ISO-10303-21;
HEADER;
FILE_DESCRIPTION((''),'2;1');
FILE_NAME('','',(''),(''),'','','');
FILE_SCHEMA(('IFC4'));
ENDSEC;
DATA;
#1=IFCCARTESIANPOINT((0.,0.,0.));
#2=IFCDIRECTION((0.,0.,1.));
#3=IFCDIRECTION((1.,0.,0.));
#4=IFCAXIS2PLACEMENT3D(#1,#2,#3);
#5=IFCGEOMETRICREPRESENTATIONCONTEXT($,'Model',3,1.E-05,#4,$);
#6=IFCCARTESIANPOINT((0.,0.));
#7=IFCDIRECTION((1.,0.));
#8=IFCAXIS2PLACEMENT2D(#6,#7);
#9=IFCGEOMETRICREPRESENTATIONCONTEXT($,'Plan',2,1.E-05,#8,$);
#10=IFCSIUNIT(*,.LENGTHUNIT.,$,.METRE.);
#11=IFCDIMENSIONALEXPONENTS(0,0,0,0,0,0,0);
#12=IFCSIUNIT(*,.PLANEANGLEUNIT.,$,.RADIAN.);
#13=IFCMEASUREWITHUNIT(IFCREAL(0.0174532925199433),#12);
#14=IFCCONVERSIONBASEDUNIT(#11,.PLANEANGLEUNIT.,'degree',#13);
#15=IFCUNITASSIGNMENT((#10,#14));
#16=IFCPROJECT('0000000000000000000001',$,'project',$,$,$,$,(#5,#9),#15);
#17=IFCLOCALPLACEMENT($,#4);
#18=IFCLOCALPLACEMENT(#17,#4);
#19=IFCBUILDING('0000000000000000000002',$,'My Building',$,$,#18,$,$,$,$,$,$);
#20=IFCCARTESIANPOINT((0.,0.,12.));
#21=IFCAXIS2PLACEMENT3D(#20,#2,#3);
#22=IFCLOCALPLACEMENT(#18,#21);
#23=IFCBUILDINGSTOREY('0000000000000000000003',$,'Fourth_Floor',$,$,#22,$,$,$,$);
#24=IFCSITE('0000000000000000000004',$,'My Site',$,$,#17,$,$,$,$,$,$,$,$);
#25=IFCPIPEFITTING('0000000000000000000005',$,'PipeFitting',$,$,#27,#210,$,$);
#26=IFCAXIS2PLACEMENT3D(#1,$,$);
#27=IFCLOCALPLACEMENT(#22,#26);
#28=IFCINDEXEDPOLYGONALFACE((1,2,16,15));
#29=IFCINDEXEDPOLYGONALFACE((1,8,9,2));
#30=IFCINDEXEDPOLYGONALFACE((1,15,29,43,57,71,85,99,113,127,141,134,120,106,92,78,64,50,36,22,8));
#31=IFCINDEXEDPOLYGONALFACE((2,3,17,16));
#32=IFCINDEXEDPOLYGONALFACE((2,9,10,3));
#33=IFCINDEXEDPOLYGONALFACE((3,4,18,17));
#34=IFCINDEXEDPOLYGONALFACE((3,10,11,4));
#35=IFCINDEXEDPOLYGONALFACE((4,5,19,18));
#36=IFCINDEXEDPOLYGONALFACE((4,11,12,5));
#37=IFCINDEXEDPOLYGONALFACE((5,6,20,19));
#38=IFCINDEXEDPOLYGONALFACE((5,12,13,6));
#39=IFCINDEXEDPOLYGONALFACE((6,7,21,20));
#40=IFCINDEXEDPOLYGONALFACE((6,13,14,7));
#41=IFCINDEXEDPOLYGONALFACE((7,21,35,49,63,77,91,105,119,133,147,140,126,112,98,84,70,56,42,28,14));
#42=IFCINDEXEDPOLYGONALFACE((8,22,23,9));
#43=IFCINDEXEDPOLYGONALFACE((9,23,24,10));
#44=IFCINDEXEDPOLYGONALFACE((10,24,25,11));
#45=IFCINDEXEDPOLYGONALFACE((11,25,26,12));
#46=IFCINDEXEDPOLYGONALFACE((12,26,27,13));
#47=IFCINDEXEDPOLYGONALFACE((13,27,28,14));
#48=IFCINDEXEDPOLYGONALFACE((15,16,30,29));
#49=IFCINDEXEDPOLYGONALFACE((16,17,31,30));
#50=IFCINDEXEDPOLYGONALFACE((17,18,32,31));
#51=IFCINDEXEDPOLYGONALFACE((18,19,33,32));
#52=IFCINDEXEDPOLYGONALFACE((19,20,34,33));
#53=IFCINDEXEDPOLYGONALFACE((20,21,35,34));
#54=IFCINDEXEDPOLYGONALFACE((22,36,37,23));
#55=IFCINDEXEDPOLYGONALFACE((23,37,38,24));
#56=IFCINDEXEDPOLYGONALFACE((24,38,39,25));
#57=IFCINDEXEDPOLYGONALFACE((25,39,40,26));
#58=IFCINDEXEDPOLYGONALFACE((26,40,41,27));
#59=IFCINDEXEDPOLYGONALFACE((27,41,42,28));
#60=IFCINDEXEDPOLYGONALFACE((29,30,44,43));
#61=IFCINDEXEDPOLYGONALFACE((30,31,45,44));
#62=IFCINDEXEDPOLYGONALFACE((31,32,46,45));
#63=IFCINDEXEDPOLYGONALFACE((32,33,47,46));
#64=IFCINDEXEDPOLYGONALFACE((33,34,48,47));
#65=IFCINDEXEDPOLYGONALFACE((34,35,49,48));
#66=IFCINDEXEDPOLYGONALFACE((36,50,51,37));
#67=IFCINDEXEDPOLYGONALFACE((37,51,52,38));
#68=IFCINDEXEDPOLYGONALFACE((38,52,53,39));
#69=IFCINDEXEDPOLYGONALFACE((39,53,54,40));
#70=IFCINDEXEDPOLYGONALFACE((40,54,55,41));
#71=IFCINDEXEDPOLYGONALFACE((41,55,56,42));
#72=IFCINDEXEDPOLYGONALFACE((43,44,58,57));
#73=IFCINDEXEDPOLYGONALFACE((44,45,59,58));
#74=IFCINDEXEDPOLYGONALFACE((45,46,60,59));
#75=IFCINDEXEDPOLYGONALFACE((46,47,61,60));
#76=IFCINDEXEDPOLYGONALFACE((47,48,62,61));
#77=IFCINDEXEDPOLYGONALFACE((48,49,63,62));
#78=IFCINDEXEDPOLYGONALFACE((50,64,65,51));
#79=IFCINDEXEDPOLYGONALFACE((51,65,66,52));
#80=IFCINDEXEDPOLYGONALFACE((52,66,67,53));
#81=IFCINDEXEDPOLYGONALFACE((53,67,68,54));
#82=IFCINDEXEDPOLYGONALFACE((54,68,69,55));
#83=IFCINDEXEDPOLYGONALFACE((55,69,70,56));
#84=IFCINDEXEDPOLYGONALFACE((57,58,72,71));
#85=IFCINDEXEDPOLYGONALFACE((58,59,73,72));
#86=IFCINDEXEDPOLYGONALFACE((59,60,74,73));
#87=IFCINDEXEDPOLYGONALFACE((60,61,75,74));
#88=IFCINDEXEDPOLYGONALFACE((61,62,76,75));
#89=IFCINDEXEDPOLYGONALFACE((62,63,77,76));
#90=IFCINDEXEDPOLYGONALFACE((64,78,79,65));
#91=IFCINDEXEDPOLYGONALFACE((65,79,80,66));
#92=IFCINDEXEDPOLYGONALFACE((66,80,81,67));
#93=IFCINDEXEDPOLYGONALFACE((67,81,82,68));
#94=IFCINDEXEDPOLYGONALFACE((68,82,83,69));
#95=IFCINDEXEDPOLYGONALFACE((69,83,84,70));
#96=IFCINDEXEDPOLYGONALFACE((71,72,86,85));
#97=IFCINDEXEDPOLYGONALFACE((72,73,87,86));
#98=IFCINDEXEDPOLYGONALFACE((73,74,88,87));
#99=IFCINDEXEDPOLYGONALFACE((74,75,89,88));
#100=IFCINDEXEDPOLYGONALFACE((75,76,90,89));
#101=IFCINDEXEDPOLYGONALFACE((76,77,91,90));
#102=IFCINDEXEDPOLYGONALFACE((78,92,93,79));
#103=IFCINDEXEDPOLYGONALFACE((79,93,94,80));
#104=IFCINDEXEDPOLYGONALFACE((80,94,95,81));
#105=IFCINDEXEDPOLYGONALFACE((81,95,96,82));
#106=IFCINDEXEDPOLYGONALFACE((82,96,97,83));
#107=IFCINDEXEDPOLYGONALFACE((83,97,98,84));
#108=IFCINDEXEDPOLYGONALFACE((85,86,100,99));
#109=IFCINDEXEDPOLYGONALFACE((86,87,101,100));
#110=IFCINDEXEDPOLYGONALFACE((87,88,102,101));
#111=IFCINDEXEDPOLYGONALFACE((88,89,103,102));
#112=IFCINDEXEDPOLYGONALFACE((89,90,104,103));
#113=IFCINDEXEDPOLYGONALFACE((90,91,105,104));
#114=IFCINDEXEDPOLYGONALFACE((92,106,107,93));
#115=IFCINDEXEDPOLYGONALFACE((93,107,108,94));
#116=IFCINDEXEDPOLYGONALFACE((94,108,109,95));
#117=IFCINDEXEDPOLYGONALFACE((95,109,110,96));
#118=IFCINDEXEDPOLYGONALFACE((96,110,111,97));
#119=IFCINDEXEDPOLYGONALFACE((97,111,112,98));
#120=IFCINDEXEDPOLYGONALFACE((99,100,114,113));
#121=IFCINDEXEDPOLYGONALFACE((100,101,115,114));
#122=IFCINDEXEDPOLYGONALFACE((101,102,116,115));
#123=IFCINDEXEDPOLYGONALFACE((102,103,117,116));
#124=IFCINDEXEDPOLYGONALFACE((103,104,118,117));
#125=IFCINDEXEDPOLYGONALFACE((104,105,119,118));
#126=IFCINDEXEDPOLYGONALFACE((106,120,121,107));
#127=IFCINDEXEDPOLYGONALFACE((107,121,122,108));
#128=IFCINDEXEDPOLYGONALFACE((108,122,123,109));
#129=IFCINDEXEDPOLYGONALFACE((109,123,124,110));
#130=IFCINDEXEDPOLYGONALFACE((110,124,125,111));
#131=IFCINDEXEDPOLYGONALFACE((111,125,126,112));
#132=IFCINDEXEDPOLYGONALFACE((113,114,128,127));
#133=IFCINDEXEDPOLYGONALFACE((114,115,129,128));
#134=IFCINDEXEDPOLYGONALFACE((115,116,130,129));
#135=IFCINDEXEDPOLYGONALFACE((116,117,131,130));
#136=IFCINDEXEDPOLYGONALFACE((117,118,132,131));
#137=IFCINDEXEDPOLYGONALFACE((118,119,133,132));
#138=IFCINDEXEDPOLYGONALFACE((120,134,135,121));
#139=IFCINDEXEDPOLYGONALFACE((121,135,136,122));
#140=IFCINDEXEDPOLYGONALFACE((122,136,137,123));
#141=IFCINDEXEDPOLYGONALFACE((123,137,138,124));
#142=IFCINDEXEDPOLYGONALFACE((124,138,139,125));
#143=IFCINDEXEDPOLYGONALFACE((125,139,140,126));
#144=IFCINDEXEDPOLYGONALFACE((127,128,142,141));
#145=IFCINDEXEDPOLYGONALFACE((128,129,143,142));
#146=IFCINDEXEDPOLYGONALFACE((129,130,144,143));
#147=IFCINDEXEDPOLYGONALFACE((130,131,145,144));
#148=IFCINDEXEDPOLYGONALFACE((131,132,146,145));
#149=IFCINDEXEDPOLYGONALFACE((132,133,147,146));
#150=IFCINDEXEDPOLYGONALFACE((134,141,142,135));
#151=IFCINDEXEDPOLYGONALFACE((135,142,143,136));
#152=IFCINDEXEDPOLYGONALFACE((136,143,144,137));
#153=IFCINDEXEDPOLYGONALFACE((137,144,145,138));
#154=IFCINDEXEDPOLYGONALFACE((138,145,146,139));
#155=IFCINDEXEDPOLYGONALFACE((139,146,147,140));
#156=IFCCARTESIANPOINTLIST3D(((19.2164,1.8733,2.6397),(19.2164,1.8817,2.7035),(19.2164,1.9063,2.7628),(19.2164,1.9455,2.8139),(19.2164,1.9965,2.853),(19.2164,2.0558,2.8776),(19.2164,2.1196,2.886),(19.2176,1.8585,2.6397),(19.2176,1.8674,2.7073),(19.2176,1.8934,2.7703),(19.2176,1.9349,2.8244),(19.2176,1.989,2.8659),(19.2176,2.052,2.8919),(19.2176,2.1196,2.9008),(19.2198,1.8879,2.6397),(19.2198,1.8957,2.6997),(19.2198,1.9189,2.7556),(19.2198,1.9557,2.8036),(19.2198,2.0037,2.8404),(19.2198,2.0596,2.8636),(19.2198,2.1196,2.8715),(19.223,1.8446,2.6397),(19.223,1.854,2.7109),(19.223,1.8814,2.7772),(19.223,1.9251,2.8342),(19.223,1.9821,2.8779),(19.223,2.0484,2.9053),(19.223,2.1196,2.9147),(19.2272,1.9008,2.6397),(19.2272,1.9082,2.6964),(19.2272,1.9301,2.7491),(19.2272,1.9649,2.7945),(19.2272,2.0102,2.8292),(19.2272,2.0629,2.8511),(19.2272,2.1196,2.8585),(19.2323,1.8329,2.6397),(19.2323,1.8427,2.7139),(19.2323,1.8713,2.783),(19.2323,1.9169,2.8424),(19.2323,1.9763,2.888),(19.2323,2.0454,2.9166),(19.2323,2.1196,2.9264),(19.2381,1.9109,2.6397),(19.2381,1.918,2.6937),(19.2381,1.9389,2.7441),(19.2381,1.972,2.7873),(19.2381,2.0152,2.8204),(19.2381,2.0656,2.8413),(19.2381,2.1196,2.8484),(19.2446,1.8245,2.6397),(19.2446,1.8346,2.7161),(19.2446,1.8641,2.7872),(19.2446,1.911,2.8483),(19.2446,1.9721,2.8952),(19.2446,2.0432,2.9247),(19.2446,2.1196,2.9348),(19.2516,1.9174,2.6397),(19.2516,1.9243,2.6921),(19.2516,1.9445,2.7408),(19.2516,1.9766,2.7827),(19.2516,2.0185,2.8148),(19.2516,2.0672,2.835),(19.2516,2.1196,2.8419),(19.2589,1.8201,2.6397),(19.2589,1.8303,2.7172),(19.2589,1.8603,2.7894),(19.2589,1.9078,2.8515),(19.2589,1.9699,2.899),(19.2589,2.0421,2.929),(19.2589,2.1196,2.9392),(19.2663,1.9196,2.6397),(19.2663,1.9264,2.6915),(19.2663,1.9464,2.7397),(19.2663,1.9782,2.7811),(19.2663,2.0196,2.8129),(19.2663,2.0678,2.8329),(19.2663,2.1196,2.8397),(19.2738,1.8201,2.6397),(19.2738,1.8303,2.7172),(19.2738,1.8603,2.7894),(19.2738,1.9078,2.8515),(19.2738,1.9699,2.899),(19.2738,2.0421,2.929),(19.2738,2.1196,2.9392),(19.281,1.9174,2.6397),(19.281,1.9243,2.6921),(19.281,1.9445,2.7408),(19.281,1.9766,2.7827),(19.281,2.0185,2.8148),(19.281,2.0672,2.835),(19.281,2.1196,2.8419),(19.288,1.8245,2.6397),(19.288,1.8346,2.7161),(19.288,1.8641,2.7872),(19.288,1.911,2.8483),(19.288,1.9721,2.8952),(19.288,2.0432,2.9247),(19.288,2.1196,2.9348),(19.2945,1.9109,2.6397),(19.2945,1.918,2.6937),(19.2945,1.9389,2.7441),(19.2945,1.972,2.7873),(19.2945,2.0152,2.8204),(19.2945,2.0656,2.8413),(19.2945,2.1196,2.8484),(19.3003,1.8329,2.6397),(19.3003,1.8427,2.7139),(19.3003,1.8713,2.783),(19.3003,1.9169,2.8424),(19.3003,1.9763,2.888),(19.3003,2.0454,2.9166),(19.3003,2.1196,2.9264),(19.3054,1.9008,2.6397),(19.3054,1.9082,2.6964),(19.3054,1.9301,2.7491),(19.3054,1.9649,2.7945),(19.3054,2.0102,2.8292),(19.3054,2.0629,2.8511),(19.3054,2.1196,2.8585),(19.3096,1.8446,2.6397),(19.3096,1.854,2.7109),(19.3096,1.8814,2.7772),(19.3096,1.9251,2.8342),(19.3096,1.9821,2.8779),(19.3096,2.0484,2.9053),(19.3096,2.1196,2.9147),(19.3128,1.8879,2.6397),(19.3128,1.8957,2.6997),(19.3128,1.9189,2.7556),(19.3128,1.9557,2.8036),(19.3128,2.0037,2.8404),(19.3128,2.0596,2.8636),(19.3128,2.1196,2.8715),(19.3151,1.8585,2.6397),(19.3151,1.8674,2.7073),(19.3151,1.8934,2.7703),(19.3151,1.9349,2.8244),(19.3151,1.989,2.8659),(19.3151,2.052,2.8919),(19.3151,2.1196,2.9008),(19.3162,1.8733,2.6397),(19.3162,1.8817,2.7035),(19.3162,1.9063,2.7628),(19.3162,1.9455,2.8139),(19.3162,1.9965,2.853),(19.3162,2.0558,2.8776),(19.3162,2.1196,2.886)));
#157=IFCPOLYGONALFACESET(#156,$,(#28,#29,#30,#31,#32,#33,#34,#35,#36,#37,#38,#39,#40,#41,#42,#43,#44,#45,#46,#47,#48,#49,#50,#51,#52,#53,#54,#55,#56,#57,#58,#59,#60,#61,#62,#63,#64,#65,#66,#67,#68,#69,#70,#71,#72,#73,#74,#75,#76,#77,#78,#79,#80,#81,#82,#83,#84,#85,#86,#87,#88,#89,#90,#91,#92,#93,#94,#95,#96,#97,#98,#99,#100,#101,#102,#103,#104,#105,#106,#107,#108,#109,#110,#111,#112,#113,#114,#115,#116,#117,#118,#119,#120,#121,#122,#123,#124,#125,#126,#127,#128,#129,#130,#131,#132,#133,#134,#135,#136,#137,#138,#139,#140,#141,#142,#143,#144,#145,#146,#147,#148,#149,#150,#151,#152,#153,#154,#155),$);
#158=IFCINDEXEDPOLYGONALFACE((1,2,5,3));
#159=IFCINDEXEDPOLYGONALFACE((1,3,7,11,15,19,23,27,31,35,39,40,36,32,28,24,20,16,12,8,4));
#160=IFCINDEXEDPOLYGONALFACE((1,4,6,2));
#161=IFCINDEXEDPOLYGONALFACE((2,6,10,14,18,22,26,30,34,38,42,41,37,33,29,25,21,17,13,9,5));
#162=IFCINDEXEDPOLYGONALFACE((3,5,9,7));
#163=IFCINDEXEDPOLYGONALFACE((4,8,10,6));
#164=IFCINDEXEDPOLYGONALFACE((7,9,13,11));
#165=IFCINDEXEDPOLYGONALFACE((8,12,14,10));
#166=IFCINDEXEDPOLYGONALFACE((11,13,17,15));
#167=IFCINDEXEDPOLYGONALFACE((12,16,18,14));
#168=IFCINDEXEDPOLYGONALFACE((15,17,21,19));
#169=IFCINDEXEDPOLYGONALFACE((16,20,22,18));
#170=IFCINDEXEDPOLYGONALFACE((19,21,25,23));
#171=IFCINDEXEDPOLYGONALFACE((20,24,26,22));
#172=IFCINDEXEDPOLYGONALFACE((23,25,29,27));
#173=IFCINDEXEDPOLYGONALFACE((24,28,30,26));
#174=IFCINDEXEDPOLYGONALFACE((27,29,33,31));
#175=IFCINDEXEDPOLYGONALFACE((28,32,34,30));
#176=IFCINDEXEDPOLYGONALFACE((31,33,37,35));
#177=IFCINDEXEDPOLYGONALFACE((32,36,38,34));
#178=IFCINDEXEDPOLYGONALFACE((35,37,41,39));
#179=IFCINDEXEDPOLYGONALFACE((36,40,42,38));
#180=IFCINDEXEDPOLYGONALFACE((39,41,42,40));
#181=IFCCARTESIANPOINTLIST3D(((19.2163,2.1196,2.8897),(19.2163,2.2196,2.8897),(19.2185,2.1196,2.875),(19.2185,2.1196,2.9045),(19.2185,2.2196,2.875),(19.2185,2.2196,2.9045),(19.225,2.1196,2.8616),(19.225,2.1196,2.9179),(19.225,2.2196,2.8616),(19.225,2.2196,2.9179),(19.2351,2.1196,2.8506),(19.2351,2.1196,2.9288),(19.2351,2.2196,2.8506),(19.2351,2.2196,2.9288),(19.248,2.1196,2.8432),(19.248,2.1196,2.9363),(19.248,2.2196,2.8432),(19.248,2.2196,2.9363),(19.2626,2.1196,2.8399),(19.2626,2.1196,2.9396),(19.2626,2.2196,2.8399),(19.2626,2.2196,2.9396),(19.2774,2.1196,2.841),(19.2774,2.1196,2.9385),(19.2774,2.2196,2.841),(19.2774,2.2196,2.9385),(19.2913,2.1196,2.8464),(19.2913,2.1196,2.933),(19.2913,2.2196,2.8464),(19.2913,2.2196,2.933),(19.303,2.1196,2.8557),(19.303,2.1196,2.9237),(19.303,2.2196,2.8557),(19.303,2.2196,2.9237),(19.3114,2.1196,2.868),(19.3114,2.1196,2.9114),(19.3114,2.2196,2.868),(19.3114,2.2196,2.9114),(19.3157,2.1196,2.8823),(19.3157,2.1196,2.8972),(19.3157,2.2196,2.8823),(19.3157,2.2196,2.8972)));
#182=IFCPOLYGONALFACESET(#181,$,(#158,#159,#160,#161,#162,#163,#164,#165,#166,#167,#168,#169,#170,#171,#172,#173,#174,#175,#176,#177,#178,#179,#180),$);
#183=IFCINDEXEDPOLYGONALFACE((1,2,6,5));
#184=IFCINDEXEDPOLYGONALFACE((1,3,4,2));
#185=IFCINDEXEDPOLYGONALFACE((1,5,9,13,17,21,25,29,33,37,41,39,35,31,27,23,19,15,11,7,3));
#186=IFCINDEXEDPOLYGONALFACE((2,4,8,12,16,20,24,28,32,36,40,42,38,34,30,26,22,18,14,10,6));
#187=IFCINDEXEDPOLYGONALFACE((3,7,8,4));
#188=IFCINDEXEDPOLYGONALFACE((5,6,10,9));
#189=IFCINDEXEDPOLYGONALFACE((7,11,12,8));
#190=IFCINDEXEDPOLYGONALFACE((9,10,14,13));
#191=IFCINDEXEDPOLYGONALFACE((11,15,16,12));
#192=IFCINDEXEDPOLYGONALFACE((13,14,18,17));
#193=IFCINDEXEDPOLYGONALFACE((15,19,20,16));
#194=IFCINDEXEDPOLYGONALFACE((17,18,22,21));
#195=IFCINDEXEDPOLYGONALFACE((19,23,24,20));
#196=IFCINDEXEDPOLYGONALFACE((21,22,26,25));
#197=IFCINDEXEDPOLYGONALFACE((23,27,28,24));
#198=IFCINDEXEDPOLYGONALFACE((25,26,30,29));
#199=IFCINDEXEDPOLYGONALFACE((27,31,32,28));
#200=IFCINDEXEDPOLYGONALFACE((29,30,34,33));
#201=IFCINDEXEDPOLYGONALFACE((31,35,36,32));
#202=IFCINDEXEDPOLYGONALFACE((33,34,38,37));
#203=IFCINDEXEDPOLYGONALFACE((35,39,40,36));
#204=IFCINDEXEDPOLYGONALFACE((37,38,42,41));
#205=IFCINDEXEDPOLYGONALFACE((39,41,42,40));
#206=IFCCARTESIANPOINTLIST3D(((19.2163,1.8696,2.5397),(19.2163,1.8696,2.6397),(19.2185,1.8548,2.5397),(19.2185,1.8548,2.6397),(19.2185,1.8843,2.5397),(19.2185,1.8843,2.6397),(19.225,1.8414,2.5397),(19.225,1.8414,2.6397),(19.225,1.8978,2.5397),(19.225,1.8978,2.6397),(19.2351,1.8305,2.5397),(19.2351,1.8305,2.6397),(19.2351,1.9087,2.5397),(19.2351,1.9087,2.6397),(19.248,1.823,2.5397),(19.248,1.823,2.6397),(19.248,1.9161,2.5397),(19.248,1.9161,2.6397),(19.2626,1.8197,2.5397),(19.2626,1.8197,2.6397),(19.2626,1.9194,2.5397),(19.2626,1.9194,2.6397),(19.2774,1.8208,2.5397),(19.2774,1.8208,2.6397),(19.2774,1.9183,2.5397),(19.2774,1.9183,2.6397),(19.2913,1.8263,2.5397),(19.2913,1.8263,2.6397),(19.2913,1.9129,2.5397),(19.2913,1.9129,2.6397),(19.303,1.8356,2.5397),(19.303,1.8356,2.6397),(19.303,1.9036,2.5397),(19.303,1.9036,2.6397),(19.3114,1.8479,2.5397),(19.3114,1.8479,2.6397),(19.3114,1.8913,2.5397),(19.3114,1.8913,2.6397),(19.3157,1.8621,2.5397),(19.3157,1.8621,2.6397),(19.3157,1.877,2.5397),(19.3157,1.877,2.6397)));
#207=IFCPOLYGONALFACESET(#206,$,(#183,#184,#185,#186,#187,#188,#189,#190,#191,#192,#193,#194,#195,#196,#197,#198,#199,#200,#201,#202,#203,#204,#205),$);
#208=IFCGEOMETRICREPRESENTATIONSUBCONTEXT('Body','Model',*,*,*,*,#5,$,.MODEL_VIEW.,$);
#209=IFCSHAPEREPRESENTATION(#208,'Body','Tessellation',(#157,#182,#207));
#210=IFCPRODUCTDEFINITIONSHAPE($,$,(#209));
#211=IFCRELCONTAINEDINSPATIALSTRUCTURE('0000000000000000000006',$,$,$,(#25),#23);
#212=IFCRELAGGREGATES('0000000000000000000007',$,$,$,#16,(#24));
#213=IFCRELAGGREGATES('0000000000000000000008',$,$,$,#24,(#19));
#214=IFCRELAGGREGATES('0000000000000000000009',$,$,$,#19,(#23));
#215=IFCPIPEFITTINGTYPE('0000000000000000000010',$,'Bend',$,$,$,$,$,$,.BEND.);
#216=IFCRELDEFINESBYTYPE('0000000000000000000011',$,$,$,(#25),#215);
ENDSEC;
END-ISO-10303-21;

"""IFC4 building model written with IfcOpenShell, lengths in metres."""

from ifc_helpers import new_model, entity, si_unit, converted_unit, frame, origin_with_axes, origin_2d_with_axis, place, context, subcontext, project, spatial, circle, extrude, source, transform, mapped, type_object, type_shapes, element, save


model = new_model("IFC4")

# Units and contexts
model_context = context("Model", 3, precision=1e-05, world=origin_with_axes())
plan_context = context("Plan", 2, precision=1e-05, world=origin_2d_with_axis())
body_context_1 = subcontext(model_context, "Body", "Model", "MODEL_VIEW")
ifc_project = project(units=[si_unit("LENGTHUNIT", "METRE"), converted_unit("PLANEANGLEUNIT", "degree", entity("IfcReal", 0.0174532925199433), si_unit("PLANEANGLEUNIT", "RADIAN"), dimensions=[0, 0, 0, 0, 0, 0, 0])], contexts=[model_context, plan_context])

# Site, building, storey
site_placement = place(None, origin_with_axes())
site = spatial("IfcSite", under=ifc_project, at=site_placement, Name="My Site")
building_placement = place(site_placement, origin_with_axes())
building = spatial("IfcBuilding", under=site, at=building_placement, Name="My Building")
storey_placement = place(building_placement, frame((0.0, 0.0, 12.0), z_axis=(0.0, 0.0, 1.0), x_axis=(1.0, 0.0, 0.0)))
storey = spatial("IfcBuildingStorey", under=building, at=storey_placement, Name="Fourth_Floor")

# Pipe fitting
pipe_fitting_type = type_object("IfcPipeFittingType", Name="Bend", PredefinedType="BEND")
shared_shape_1 = source(origin_with_axes(), body_context_1, "Body", "SolidModel", [
    entity("IfcSweptDiskSolid", entity("IfcIndexedPolyCurve", entity("IfcCartesianPointList3D", [[0.0, 0.0, -0.1], [0.0, -0.0732, -0.2768], [0.0, -0.25, -0.35]]), [entity("IfcArcIndex", [1, 2, 3])]), 0.05),
    extrude(circle(Radius=0.05), origin_with_axes(), (0.0, 0.0, -1.0), 0.1),
    extrude(circle(Radius=0.05), frame((0.0, -0.25, -0.35), z_axis=(0.0, -1.0, 0.0), x_axis=(1.0, 0.0, 0.0)), (0.0, 0.0, 1.0), 0.1),
])
type_shapes(pipe_fitting_type, [shared_shape_1])
for number, where, z_axis, x_axis, name in (
    (1, (19.2663, 2.2196, 2.8897), (0.0, 1.0, 0.0), (-1.0, 0.0, 0.0), "PipeFitting"),
):
    element("IfcPipeFitting", number, at=place(storey_placement, frame(where, z_axis=z_axis, x_axis=x_axis)), inside=storey, type_object=pipe_fitting_type, Name=name, context=body_context_1, shape_type="MappedRepresentation", body=[
        mapped(shared_shape_1, transform((0.0, 0.0, 0.0), x_axis=(1.0, 0.0, 0.0), y_axis=(0.0, 1.0, 0.0), z_axis=(0.0, 0.0, 1.0), scale=1.0)),
    ])

save(model, "model.ifc")
